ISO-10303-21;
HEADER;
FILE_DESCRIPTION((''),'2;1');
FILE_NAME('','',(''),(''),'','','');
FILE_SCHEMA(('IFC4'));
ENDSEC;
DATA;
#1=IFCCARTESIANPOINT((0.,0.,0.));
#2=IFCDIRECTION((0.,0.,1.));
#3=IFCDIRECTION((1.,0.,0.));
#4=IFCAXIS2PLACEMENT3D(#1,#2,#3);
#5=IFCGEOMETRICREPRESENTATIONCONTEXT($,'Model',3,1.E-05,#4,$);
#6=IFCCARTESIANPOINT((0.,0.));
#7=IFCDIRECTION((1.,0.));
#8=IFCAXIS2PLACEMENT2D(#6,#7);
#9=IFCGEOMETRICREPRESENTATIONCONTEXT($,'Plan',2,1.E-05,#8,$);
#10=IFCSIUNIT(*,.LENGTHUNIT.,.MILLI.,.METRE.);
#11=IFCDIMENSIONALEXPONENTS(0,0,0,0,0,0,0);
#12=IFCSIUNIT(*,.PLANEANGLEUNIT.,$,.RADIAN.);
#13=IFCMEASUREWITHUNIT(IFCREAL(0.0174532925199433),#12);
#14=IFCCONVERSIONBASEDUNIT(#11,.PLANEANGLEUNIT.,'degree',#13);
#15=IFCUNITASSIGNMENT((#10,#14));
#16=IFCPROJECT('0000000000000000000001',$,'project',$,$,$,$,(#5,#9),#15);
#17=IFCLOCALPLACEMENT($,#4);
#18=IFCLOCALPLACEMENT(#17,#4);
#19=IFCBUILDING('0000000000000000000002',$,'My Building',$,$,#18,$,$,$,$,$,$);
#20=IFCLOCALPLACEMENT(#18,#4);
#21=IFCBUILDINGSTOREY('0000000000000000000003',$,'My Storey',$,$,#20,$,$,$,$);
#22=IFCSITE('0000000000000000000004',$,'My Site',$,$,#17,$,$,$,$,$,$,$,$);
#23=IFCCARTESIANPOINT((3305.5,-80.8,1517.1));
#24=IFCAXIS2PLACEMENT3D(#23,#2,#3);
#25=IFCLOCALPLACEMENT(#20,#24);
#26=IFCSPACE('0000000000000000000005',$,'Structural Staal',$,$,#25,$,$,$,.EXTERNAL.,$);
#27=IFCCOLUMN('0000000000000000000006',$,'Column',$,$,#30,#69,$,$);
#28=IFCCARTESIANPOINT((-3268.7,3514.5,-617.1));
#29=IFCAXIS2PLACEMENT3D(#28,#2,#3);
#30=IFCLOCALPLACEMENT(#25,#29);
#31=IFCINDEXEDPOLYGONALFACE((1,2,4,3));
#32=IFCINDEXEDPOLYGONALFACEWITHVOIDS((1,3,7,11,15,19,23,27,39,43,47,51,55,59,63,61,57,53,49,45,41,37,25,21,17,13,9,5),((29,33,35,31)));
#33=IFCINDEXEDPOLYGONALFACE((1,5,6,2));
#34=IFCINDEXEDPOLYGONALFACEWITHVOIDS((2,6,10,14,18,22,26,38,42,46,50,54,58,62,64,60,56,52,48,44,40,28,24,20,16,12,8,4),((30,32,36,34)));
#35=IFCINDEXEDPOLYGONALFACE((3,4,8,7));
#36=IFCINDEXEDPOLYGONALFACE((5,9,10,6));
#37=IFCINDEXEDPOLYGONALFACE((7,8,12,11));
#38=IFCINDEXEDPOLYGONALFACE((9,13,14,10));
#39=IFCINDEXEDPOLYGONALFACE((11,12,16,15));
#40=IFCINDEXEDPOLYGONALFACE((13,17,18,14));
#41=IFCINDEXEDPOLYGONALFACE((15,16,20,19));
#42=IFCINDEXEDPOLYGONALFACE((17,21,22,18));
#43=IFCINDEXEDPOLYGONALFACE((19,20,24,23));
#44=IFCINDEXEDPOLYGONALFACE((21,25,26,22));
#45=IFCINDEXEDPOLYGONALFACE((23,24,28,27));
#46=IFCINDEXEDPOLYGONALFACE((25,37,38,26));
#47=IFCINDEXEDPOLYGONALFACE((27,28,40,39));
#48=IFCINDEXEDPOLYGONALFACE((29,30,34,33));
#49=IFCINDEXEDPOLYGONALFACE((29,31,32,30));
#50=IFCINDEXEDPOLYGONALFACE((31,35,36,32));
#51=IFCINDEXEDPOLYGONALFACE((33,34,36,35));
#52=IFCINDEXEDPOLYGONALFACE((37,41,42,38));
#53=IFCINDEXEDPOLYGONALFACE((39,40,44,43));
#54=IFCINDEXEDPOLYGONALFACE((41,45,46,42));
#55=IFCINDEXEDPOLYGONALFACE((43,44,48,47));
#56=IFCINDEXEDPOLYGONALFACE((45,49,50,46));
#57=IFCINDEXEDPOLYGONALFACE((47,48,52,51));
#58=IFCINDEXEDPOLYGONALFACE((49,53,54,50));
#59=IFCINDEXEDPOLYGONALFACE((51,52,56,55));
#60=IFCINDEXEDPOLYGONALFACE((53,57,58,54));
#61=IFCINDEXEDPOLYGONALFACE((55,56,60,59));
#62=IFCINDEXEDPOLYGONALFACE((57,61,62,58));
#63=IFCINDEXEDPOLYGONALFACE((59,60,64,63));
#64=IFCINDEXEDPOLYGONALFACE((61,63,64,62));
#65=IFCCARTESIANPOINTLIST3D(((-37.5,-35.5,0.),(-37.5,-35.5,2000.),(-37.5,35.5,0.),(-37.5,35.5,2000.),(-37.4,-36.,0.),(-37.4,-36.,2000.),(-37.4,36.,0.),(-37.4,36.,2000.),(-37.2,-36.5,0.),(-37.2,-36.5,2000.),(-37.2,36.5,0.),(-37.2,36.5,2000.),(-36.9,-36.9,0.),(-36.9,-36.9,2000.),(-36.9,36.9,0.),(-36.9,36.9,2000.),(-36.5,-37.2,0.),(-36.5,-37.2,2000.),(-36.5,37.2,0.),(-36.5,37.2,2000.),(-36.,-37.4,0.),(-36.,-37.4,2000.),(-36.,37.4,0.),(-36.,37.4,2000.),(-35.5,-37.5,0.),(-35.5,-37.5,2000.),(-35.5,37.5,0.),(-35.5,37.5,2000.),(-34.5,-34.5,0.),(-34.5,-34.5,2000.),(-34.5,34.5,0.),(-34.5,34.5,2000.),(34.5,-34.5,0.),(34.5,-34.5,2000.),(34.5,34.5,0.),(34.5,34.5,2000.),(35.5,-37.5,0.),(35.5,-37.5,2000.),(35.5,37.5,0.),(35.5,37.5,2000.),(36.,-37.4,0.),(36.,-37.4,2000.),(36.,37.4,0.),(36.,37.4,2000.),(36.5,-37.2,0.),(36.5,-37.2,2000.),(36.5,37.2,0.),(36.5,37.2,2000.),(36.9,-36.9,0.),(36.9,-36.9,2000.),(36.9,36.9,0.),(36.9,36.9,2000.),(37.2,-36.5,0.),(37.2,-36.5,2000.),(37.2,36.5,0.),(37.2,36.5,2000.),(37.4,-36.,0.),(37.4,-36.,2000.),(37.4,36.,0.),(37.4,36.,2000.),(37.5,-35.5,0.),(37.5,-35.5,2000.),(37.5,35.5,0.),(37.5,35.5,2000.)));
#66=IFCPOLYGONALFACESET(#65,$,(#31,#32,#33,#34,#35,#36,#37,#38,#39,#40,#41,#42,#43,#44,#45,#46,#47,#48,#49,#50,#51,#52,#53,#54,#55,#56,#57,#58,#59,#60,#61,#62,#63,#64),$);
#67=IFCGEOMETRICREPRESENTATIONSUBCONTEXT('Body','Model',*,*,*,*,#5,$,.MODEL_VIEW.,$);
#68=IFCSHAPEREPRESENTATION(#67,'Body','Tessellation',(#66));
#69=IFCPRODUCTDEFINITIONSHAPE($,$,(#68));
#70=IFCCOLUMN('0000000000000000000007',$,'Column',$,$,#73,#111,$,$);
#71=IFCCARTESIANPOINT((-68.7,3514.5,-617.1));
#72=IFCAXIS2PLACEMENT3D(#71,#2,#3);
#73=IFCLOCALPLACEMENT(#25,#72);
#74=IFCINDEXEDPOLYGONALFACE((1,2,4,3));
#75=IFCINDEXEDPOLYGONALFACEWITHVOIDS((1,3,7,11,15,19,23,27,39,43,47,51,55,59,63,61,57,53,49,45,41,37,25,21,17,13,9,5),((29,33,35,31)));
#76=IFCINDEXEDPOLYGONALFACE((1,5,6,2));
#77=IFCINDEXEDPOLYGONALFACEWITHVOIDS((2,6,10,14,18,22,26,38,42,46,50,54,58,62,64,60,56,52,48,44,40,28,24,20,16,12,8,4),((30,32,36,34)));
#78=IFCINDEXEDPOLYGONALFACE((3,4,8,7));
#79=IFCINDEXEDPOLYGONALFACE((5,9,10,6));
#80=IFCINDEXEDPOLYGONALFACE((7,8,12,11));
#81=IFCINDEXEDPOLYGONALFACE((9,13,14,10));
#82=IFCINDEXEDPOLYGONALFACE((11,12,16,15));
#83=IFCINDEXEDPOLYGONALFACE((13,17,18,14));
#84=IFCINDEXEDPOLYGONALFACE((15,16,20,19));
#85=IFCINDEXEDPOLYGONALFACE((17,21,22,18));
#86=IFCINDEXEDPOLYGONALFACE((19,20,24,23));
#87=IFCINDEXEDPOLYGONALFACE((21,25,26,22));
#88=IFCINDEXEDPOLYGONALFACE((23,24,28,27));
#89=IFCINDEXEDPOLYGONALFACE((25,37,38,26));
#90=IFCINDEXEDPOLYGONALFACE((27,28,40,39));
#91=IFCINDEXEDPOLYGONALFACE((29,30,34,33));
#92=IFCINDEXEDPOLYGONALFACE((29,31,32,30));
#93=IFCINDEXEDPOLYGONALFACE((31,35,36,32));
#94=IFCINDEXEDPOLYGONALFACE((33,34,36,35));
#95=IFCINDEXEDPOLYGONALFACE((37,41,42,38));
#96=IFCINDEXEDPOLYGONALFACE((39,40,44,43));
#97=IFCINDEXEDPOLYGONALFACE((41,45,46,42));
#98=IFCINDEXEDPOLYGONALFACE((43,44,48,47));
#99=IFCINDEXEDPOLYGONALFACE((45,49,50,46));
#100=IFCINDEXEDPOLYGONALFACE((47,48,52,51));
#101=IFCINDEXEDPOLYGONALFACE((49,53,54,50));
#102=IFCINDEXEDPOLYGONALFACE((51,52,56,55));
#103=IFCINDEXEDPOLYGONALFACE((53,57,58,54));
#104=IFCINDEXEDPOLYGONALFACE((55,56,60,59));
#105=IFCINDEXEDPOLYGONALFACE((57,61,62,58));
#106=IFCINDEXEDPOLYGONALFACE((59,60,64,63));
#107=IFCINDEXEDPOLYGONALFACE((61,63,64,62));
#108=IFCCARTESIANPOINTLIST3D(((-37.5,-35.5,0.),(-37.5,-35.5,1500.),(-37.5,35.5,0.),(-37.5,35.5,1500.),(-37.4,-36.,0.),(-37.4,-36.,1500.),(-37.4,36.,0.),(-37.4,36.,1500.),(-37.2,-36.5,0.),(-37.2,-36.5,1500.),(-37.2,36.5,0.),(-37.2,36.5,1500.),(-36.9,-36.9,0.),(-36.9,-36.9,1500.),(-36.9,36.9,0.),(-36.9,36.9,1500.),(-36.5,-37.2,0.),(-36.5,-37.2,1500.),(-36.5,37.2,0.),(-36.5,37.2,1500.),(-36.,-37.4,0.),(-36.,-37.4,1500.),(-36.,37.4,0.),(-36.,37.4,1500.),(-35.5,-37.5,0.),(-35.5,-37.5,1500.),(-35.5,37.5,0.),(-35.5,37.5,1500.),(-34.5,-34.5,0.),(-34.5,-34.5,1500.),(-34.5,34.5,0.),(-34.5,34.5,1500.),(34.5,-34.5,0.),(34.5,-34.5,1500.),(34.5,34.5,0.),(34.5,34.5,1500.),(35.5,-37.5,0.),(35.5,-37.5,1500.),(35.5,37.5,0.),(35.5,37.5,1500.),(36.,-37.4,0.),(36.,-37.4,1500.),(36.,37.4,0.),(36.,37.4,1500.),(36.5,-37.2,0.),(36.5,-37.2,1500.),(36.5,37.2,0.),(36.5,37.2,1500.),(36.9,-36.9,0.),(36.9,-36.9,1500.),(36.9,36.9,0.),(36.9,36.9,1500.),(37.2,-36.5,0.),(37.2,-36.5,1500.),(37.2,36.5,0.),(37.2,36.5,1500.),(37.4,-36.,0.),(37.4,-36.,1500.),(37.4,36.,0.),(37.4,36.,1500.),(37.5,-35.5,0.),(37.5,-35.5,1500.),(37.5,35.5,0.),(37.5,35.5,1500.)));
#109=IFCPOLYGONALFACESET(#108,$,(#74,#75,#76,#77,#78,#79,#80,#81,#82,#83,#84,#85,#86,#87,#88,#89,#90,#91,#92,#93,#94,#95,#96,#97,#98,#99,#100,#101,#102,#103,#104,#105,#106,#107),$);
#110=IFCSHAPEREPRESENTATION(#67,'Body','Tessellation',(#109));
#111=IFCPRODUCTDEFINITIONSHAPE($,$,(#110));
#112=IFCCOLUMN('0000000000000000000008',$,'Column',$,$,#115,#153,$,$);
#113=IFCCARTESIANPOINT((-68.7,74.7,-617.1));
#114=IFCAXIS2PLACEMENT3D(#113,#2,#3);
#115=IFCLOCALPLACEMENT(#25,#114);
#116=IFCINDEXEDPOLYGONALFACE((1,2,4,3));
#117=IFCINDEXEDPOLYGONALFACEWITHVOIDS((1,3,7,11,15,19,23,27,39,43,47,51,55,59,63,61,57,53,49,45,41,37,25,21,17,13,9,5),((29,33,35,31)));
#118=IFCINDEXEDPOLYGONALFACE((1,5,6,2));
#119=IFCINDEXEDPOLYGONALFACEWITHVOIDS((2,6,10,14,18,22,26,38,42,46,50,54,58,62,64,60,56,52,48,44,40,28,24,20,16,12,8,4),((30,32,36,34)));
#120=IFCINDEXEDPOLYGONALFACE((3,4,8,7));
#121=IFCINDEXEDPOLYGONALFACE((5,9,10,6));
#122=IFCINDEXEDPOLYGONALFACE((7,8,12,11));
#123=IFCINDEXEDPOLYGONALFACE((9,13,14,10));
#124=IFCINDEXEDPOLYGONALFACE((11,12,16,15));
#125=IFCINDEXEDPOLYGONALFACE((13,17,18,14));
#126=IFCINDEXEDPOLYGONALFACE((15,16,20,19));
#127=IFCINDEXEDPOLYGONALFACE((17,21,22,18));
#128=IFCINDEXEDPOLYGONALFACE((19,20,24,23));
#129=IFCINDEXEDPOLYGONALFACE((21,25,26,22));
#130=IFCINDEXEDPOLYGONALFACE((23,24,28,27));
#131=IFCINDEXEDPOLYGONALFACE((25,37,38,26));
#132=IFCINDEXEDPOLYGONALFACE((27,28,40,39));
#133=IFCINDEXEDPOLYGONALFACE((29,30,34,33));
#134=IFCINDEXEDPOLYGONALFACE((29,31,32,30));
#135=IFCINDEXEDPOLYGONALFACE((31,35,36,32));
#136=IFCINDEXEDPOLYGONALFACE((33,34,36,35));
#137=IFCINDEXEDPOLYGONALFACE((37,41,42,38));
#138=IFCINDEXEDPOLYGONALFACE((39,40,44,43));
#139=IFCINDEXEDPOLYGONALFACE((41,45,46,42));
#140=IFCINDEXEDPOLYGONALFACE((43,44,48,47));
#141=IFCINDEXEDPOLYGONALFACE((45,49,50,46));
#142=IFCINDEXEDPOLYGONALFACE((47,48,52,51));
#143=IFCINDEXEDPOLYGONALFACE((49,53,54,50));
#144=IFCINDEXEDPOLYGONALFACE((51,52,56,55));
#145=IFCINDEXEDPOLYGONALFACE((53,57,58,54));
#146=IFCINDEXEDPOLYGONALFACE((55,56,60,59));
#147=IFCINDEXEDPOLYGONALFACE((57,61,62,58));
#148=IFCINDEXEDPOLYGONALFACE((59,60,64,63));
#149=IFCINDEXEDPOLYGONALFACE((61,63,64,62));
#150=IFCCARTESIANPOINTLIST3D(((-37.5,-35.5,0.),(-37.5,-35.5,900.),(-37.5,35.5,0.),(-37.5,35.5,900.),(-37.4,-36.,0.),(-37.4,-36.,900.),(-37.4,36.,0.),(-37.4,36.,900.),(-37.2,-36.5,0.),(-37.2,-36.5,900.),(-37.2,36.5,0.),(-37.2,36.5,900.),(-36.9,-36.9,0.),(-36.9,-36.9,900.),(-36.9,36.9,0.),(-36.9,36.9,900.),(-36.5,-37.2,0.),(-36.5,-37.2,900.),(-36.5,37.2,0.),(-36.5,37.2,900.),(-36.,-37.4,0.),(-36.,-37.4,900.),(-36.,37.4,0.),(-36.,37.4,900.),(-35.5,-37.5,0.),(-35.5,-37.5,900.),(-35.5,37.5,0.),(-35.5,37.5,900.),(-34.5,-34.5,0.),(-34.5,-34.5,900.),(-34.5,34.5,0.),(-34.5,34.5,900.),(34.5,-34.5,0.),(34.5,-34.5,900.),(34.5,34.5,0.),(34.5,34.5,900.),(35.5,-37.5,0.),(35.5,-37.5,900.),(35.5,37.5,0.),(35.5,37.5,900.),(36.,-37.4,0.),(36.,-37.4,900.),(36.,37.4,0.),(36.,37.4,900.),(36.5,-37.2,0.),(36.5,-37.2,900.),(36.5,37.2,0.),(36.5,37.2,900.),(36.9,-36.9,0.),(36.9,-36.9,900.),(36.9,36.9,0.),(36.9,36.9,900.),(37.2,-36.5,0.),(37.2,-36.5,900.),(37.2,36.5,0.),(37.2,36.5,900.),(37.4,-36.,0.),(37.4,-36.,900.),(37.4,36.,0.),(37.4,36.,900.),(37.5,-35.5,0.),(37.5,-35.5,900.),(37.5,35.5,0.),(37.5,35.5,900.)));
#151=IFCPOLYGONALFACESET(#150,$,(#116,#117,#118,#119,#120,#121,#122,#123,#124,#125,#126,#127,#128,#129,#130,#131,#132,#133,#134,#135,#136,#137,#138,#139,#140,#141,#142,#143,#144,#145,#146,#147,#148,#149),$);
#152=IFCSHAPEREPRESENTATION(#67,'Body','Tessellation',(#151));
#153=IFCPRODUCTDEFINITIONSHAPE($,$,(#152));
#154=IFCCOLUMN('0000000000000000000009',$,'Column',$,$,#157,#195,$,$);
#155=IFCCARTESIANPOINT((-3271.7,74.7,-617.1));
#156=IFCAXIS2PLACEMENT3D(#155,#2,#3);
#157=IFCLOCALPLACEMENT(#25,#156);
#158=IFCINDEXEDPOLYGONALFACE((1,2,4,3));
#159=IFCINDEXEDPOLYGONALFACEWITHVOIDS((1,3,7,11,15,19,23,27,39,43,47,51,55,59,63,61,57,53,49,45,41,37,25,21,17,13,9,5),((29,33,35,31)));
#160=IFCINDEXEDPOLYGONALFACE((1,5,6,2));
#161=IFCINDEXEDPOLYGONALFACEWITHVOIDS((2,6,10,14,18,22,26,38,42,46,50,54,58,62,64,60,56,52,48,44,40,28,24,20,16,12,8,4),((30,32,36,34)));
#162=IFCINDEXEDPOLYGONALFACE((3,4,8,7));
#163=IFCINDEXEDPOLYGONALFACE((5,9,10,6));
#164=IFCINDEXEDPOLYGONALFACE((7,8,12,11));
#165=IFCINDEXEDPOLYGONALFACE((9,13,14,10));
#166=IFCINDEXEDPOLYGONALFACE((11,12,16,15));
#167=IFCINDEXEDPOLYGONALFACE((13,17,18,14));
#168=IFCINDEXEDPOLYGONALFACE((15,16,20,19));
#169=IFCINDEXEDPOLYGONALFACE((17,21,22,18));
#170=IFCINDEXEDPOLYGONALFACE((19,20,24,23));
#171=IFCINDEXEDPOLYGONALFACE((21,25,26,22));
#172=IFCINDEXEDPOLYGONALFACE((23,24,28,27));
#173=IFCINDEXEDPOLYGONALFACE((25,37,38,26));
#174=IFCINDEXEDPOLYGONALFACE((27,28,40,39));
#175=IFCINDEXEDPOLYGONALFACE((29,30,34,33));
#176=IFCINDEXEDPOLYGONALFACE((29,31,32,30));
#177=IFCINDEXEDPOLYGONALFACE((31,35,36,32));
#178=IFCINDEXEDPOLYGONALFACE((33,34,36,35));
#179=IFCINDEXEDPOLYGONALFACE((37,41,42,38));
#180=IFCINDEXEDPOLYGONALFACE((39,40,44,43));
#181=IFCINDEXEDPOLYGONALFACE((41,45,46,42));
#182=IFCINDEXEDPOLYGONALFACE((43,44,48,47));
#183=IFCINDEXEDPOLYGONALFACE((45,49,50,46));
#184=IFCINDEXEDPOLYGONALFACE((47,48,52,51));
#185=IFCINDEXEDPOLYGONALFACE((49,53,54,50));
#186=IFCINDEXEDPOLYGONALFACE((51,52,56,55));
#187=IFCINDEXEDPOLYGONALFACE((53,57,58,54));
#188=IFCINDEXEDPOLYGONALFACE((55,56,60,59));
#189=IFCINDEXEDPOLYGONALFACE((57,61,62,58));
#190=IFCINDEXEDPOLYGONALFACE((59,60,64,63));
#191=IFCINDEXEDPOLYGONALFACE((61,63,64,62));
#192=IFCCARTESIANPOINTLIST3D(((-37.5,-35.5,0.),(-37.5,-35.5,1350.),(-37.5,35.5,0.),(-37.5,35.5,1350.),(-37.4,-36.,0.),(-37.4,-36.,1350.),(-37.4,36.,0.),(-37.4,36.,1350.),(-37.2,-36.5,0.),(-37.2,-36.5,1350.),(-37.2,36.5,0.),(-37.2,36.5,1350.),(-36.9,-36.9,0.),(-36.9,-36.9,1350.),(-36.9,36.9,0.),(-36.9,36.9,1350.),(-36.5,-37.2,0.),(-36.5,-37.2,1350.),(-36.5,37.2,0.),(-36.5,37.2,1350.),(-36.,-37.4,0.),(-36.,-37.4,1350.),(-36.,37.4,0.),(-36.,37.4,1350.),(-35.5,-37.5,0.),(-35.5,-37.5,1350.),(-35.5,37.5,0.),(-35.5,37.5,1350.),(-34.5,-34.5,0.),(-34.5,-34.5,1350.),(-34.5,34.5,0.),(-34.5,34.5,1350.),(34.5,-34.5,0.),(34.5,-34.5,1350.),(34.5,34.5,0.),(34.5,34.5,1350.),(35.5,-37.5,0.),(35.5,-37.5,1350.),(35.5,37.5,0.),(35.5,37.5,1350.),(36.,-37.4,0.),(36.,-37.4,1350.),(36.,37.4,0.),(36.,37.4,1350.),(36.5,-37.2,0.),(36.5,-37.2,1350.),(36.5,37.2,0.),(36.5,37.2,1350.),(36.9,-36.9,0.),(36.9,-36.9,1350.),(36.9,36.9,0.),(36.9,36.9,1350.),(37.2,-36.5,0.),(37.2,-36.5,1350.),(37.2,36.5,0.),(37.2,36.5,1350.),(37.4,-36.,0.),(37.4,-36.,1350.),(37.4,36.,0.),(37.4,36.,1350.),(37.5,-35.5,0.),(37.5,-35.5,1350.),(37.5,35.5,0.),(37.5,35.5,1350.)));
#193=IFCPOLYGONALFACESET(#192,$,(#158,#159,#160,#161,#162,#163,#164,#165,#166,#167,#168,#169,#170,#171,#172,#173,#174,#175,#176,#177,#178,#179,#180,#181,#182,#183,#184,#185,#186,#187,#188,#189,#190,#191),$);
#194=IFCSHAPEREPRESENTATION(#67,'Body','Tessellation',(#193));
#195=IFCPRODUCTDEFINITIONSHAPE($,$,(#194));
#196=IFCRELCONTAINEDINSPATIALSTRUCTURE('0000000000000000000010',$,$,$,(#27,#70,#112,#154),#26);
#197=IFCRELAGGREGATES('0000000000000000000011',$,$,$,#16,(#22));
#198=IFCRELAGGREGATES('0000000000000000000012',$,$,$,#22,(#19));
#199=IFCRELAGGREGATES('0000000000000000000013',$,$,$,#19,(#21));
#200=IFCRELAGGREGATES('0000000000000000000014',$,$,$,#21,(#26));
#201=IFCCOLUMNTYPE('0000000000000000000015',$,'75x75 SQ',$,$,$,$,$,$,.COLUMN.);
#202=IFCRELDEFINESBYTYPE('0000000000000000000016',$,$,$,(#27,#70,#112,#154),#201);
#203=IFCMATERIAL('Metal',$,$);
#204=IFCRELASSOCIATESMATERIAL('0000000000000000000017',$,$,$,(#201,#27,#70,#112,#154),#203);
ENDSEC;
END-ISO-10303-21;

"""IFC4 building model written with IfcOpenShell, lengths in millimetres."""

from ifc_helpers import new_model, entity, si_unit, converted_unit, frame, origin_with_axes, origin_2d_with_axis, place, context, subcontext, project, spatial, hollow_rectangle, extrude, material, material_profile, profile_set, profile_usage, type_object, element, save


model = new_model("IFC4")

# Units and contexts
model_context = context("Model", 3, precision=1e-05, world=origin_with_axes())
plan_context = context("Plan", 2, precision=1e-05, world=origin_2d_with_axis())
body_context = subcontext(model_context, "Body", "Model", "MODEL_VIEW")
ifc_project = project(units=[si_unit("LENGTHUNIT", "METRE", prefix="MILLI"), converted_unit("PLANEANGLEUNIT", "degree", entity("IfcReal", 0.0174532925199433), si_unit("PLANEANGLEUNIT", "RADIAN"), dimensions=[0, 0, 0, 0, 0, 0, 0])], contexts=[model_context, plan_context])

# Site, building, storey
site_placement = place(None, origin_with_axes())
site = spatial("IfcSite", under=ifc_project, at=site_placement, Name="My Site")
building_placement = place(site_placement, origin_with_axes())
building = spatial("IfcBuilding", under=site, at=building_placement, Name="My Building")
storey_placement = place(building_placement, origin_with_axes())
storey = spatial("IfcBuildingStorey", under=building, at=storey_placement, Name="My Storey")

# Shared definitions
space_1_placement = place(storey_placement, frame((3305.5, -80.8, 1517.1), z_axis=(0.0, 0.0, 1.0), x_axis=(1.0, 0.0, 0.0)))
space_1 = spatial("IfcSpace", under=storey, at=space_1_placement, Name="Structural Staal", PredefinedType="EXTERNAL")

# Columns
ifc_material_1 = material(Name="Metal")
ifc_material_profile_1 = material_profile(ifc_material_1, hollow_rectangle(XDim=75.0, YDim=75.0, WallThickness=3.0, OuterFilletRadius=2.0))
ifc_profile_set_1 = profile_set([ifc_material_profile_1])
ifc_profile_usage_1 = profile_usage(ifc_profile_set_1, cardinal=5)
column_type_1 = type_object("IfcColumnType", Name="75x75 SQ", PredefinedType="COLUMN", material=ifc_profile_set_1)
column_1_placement = place(space_1_placement, frame((-3268.7, 3514.5, -617.1), z_axis=(0.0, 0.0, 1.0), x_axis=(1.0, 0.0, 0.0)))
element("IfcColumn", 1, at=column_1_placement, inside=space_1, type_object=column_type_1, material=ifc_profile_usage_1, Name="Column", context=body_context, shape_type="SweptSolid", body=[
    extrude(hollow_rectangle(XDim=75.0, YDim=75.0, WallThickness=3.0, OuterFilletRadius=2.0), origin_with_axes(), (0.0, 0.0, 1.0), 2000.0),
])
ifc_profile_usage_2 = profile_usage(ifc_profile_set_1, cardinal=5)
column_2_placement = place(space_1_placement, frame((-68.7, 3514.5, -617.1), z_axis=(0.0, 0.0, 1.0), x_axis=(1.0, 0.0, 0.0)))
element("IfcColumn", 2, at=column_2_placement, inside=space_1, type_object=column_type_1, material=ifc_profile_usage_2, Name="Column", context=body_context, shape_type="SweptSolid", body=[
    extrude(hollow_rectangle(XDim=75.0, YDim=75.0, WallThickness=3.0, OuterFilletRadius=2.0), origin_with_axes(), (0.0, 0.0, 1.0), 1500.0),
])
ifc_profile_usage_3 = profile_usage(ifc_profile_set_1, cardinal=5)
column_3_placement = place(space_1_placement, frame((-68.7, 74.7, -617.1), z_axis=(0.0, 0.0, 1.0), x_axis=(1.0, 0.0, 0.0)))
element("IfcColumn", 3, at=column_3_placement, inside=space_1, type_object=column_type_1, material=ifc_profile_usage_3, Name="Column", context=body_context, shape_type="SweptSolid", body=[
    extrude(hollow_rectangle(XDim=75.0, YDim=75.0, WallThickness=3.0, OuterFilletRadius=2.0), origin_with_axes(), (0.0, 0.0, 1.0), 900.0),
])
ifc_profile_usage_4 = profile_usage(ifc_profile_set_1, cardinal=5)
column_4_placement = place(space_1_placement, frame((-3271.7, 74.7, -617.1), z_axis=(0.0, 0.0, 1.0), x_axis=(1.0, 0.0, 0.0)))
element("IfcColumn", 4, at=column_4_placement, inside=space_1, type_object=column_type_1, material=ifc_profile_usage_4, Name="Column", context=body_context, shape_type="SweptSolid", body=[
    extrude(hollow_rectangle(XDim=75.0, YDim=75.0, WallThickness=3.0, OuterFilletRadius=2.0), origin_with_axes(), (0.0, 0.0, 1.0), 1350.0),
])

save(model, "model.ifc")
